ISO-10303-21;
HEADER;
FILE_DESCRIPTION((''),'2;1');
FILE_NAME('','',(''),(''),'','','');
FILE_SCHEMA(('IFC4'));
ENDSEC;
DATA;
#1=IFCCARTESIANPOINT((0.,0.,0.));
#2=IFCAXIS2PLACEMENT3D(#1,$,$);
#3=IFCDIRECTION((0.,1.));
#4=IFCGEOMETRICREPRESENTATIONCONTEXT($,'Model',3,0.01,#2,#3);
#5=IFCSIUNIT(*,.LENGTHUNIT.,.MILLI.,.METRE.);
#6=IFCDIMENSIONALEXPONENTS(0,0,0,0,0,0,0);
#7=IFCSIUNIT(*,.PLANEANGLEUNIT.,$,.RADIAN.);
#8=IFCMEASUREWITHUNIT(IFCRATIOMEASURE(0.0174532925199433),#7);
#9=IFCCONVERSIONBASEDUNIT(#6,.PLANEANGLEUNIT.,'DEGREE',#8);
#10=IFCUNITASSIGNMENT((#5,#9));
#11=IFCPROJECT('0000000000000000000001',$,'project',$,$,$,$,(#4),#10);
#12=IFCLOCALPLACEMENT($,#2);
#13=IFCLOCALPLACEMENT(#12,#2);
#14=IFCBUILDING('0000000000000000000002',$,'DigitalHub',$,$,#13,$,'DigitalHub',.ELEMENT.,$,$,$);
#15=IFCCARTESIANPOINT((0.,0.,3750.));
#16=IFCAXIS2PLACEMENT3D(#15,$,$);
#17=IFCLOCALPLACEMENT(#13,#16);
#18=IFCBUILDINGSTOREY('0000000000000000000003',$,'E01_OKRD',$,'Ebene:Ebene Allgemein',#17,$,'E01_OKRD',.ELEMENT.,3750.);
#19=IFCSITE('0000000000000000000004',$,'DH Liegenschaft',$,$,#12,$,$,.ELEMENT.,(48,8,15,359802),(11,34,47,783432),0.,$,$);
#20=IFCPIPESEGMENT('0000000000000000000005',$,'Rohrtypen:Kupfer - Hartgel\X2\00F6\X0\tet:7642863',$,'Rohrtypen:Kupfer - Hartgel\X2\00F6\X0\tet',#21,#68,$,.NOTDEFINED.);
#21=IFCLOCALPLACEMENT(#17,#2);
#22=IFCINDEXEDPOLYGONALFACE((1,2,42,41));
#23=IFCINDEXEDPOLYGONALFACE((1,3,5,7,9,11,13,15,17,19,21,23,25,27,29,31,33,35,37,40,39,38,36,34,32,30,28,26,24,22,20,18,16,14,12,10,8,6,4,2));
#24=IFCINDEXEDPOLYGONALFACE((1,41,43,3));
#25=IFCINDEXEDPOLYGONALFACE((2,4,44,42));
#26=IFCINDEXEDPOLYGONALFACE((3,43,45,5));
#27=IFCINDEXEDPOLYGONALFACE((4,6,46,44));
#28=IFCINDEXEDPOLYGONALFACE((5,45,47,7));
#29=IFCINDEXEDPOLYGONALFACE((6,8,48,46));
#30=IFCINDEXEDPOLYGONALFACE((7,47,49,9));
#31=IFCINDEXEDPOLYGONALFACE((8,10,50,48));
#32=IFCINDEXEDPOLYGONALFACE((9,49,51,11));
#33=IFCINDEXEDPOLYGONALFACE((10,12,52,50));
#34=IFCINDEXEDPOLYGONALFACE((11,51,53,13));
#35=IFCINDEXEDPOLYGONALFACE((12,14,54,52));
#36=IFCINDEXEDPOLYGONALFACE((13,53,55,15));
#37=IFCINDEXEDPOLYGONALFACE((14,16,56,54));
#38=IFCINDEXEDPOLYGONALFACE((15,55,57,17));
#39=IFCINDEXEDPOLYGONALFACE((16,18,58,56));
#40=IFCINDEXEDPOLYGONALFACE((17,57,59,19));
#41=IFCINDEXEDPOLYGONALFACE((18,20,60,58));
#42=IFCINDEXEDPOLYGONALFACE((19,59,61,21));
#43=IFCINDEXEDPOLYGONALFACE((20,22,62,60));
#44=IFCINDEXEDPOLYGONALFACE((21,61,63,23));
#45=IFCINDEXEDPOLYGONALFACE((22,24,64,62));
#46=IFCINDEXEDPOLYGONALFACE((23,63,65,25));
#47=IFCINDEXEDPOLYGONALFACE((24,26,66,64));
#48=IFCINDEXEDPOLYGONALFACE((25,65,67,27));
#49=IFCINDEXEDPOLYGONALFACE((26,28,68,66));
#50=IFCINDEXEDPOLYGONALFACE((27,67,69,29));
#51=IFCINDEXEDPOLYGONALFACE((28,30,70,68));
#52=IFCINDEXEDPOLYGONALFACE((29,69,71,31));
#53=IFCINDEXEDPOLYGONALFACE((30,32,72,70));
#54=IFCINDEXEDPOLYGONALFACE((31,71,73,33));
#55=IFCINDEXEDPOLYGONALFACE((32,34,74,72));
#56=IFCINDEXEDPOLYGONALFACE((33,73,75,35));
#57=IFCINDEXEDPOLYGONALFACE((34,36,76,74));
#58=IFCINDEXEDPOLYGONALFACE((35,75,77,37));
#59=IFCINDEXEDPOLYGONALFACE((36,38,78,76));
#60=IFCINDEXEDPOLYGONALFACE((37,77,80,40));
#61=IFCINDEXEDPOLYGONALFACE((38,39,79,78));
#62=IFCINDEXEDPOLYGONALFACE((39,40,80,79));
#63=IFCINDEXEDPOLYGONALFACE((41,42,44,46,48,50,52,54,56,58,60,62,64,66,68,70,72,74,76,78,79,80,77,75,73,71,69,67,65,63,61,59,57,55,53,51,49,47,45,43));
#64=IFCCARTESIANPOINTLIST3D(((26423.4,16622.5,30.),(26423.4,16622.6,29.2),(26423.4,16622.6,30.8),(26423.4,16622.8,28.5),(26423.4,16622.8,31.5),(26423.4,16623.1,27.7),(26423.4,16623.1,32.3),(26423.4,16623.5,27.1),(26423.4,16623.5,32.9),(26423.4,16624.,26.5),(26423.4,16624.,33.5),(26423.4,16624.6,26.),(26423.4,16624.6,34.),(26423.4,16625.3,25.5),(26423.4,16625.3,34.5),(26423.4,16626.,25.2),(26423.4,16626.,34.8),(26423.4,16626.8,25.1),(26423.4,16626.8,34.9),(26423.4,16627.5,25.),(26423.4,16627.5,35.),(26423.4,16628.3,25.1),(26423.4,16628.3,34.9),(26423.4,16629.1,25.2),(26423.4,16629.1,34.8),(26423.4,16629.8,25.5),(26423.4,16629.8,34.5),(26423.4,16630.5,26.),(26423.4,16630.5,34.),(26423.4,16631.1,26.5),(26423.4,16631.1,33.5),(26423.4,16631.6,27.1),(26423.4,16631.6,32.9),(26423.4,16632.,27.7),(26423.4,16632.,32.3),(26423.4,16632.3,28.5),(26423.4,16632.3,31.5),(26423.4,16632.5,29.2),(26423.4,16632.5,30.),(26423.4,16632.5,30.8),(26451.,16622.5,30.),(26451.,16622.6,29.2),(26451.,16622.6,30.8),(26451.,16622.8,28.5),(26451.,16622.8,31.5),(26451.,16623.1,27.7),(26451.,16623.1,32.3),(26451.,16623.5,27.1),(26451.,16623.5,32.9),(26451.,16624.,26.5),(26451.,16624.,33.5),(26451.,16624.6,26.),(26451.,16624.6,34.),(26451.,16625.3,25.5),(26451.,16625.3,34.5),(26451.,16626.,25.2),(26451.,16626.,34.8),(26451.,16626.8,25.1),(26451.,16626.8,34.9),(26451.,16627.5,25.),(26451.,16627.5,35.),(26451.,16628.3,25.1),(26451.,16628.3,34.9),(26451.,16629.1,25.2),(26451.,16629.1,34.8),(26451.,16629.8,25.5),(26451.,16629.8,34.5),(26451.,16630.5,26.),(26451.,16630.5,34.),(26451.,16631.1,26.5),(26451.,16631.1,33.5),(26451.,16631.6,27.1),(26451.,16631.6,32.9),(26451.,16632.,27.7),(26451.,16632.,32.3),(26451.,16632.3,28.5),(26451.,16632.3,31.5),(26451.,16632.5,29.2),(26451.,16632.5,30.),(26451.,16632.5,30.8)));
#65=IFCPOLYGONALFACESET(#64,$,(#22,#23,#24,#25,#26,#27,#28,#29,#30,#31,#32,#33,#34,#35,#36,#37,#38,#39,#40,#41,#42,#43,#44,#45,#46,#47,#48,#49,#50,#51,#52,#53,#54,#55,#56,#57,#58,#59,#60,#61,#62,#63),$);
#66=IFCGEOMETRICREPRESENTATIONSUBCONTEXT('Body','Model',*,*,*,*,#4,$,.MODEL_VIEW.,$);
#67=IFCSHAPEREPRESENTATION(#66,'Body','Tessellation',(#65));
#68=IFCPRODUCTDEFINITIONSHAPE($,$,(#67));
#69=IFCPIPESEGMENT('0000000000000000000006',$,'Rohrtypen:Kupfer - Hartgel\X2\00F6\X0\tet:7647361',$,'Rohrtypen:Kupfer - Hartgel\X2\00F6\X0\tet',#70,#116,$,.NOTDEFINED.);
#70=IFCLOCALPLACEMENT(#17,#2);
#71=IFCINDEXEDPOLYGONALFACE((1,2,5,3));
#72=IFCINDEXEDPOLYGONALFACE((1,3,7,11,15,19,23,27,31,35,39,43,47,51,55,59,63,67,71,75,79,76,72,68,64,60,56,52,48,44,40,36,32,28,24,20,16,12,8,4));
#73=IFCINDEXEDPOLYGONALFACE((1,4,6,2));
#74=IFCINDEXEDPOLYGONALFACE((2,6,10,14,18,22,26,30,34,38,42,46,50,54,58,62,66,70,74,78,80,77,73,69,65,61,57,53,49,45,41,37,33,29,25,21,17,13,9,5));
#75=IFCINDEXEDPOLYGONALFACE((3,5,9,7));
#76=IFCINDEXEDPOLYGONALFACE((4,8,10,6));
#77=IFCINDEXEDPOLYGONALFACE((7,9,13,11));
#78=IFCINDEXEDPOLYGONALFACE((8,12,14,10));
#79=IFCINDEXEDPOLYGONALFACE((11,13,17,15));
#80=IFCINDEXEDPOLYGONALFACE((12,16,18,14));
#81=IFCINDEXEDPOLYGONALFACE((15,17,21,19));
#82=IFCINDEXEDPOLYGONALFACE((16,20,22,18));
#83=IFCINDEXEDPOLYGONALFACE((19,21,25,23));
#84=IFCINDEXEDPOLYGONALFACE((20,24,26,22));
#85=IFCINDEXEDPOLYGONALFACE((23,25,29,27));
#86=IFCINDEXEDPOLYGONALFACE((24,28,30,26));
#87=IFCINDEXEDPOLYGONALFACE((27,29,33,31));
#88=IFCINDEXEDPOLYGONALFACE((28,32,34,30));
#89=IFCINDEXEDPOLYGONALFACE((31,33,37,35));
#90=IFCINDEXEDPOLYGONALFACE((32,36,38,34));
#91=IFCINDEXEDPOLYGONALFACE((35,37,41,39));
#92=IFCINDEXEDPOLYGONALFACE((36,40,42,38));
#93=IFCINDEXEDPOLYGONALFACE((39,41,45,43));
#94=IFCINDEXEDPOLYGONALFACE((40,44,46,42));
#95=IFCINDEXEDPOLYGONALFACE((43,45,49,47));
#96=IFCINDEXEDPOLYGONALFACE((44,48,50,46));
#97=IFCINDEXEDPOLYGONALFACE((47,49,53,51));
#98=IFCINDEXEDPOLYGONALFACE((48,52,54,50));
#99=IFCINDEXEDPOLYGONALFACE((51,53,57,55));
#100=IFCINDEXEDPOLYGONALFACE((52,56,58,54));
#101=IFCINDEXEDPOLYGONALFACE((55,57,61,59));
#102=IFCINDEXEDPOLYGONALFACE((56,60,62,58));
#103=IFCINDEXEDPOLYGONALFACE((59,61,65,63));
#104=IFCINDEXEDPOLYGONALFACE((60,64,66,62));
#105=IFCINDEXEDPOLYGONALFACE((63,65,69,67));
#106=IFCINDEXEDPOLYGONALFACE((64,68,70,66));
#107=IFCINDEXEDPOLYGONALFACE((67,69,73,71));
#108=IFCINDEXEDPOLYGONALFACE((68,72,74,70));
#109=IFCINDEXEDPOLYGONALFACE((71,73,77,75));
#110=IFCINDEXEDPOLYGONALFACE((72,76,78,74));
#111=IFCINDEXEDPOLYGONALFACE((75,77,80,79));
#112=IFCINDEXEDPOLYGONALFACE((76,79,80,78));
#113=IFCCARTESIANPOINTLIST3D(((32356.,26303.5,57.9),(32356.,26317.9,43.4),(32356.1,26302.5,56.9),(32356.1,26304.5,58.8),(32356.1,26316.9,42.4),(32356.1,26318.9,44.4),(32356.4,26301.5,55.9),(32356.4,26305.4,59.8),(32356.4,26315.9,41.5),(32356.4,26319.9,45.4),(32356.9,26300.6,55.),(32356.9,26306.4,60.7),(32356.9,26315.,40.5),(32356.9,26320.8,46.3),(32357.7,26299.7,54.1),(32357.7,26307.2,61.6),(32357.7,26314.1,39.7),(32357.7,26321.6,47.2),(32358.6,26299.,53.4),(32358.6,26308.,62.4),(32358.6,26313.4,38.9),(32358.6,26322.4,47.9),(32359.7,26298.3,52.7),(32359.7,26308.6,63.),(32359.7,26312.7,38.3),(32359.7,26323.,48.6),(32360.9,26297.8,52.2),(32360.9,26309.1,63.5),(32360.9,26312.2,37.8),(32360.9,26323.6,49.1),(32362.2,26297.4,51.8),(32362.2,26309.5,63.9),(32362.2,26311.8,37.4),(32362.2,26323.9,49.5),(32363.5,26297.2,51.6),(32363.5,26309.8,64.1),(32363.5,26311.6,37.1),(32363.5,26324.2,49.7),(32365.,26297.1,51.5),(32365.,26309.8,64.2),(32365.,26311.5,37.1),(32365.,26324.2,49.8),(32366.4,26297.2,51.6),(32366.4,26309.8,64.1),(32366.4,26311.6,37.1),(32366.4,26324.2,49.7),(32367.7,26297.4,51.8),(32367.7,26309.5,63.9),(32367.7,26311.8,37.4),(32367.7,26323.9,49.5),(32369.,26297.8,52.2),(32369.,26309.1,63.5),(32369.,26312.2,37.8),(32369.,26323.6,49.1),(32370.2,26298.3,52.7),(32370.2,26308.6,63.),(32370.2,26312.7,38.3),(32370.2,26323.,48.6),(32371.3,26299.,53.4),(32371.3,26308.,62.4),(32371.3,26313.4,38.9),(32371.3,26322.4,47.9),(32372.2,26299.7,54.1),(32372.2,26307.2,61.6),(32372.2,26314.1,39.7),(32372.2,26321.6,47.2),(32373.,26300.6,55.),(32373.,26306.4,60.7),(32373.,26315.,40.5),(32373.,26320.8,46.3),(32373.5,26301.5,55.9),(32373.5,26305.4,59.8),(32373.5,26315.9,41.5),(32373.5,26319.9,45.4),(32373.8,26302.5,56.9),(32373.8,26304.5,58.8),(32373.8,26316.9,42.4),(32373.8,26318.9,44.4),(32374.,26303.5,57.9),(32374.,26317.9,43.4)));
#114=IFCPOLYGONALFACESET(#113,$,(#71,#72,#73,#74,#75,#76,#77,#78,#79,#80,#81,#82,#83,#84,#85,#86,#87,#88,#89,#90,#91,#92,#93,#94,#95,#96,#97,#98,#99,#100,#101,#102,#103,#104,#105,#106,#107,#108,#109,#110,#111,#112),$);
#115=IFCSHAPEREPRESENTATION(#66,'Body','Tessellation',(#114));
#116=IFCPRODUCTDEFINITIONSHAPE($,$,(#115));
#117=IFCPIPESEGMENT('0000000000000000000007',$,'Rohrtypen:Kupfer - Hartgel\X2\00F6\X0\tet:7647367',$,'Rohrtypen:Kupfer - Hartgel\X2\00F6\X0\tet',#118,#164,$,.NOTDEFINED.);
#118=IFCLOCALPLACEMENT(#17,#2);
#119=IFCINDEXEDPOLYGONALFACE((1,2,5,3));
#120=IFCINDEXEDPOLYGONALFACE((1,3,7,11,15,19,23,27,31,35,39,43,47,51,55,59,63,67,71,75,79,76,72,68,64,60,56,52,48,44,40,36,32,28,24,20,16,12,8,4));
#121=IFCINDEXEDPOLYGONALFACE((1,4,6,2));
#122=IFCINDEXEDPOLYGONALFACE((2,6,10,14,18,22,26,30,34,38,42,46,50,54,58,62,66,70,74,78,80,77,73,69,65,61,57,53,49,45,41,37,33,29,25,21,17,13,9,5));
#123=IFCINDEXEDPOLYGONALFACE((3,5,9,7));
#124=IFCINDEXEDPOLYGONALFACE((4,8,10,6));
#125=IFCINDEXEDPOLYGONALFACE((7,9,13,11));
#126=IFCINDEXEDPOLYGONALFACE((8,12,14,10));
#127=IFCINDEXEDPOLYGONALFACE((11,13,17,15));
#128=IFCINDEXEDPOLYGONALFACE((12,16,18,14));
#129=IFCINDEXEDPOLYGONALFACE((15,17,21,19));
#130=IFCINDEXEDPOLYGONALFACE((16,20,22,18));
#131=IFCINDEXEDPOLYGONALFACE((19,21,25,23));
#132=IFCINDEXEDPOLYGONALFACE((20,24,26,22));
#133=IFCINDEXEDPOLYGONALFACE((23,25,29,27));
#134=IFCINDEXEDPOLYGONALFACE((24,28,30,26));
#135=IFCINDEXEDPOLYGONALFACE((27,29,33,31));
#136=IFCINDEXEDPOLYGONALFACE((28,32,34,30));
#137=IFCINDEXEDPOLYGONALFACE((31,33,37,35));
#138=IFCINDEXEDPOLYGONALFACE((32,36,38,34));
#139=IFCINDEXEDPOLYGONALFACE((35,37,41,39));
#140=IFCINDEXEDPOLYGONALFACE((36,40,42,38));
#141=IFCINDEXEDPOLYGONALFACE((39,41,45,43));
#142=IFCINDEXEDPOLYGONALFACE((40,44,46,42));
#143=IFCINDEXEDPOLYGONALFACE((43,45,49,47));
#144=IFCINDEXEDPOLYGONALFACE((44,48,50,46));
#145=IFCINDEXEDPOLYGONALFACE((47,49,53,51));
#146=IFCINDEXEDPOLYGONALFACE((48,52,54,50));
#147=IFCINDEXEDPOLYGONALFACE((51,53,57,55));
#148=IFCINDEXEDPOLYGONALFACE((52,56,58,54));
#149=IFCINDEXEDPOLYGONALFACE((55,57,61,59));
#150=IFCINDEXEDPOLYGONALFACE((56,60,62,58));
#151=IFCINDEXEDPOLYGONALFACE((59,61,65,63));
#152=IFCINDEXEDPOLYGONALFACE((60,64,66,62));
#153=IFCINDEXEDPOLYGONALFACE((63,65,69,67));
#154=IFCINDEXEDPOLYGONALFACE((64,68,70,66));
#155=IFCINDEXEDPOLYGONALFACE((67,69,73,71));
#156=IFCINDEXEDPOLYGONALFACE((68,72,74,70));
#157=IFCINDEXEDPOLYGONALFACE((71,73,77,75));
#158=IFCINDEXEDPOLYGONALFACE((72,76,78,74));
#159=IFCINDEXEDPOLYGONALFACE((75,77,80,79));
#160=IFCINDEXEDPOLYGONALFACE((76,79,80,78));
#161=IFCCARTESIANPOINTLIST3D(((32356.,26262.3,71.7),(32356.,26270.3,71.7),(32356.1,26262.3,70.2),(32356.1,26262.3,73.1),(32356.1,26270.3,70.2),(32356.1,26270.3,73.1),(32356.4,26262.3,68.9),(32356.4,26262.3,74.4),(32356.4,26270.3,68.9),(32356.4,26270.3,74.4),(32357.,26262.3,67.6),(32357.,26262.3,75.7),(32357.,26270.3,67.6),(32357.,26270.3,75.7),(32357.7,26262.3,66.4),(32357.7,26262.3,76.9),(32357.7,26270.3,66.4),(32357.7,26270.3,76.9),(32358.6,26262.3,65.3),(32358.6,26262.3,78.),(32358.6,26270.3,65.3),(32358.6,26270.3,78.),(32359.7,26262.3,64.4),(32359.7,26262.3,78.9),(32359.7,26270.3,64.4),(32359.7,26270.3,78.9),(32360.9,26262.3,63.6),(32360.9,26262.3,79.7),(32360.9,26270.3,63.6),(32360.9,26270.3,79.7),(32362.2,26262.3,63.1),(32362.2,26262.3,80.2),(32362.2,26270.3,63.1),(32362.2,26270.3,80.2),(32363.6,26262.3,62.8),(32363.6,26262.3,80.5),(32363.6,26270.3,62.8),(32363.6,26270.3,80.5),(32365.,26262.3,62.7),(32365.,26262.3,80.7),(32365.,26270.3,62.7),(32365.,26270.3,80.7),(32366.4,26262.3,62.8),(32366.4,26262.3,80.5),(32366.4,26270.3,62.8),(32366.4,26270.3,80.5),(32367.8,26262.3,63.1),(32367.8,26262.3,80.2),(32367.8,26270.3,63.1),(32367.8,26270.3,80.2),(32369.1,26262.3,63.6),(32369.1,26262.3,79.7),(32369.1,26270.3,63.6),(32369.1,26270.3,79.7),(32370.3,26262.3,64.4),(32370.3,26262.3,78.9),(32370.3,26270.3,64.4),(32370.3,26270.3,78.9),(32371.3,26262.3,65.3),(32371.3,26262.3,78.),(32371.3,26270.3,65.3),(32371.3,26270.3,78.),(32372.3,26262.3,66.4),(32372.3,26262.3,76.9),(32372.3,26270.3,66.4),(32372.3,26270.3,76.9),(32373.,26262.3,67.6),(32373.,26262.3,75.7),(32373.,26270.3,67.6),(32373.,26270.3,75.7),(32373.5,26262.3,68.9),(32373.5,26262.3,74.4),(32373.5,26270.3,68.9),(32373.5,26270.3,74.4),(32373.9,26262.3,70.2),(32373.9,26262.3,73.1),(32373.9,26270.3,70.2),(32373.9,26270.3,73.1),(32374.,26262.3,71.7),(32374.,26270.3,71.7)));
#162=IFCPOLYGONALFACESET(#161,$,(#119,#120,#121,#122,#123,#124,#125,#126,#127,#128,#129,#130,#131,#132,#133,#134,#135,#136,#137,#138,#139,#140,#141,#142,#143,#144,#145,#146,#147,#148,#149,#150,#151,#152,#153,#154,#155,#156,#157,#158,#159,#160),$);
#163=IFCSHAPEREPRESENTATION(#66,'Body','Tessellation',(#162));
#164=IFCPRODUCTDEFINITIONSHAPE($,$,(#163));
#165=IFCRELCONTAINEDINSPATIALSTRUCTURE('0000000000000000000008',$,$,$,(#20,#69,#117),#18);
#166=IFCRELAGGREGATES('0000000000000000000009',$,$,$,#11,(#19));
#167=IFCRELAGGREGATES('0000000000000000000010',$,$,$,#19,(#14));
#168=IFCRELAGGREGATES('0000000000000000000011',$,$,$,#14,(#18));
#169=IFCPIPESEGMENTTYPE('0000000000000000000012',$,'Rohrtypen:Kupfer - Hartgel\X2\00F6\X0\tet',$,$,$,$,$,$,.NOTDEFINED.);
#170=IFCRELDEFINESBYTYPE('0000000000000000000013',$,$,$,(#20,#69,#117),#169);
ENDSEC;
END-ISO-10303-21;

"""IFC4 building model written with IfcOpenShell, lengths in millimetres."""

from ifc_helpers import new_model, entity, si_unit, converted_unit, direction, frame, origin, place, context, subcontext, project, spatial, indexed_curve, outline, extrude, type_object, element, save


model = new_model("IFC4")

# Units and contexts
model_context = context("Model", 3, precision=0.01, world=origin(), true_north=direction((0.0, 1.0)))
body_context = subcontext(model_context, "Body", "Model", "MODEL_VIEW")
ifc_project = project(units=[si_unit("LENGTHUNIT", "METRE", prefix="MILLI"), converted_unit("PLANEANGLEUNIT", "DEGREE", entity("IfcRatioMeasure", 0.0174532925199433), si_unit("PLANEANGLEUNIT", "RADIAN"), dimensions=[0, 0, 0, 0, 0, 0, 0])], contexts=[model_context])

# Site, building, storey
site_placement = place(None, origin())
site = spatial("IfcSite", under=ifc_project, at=site_placement, Name="DH Liegenschaft", CompositionType="ELEMENT", RefLatitude=(48, 8, 15, 359802), RefLongitude=(11, 34, 47, 783432), RefElevation=0.0)
building_placement = place(site_placement, origin())
building = spatial("IfcBuilding", under=site, at=building_placement, Name="DigitalHub", LongName="DigitalHub", CompositionType="ELEMENT")
storey_placement = place(building_placement, frame((0.0, 0.0, 3750.0)))
storey = spatial("IfcBuildingStorey", under=building, at=storey_placement, Name="E01_OKRD", ObjectType="Ebene:Ebene Allgemein", LongName="E01_OKRD", CompositionType="ELEMENT", Elevation=3750.0)

# Pipe segments
pipe_segment_type = type_object("IfcPipeSegmentType", Name="Rohrtypen:Kupfer - Hartgelötet", PredefinedType="NOTDEFINED")
pipe_segment_1_placement = place(storey_placement, frame((26423.4, 16620.9, 23.4)))
element("IfcPipeSegment", 1, at=pipe_segment_1_placement, inside=storey, type_object=pipe_segment_type, Name="Rohrtypen:Kupfer - Hartgelötet:7642863", ObjectType="Rohrtypen:Kupfer - Hartgelötet", PredefinedType="NOTDEFINED", context=body_context, shape_type="SweptSolid", body=[
    extrude(outline(indexed_curve([(5.0, 0.0), (4.9, 0.8), (4.8, 1.5), (4.5, 2.3), (4.0, 2.9), (3.5, 3.5), (2.9, 4.0), (2.3, 4.5), (1.5, 4.8), (0.8, 4.9), (0.0, 5.0), (-0.8, 4.9), (-1.5, 4.8), (-2.3, 4.5), (-2.9, 4.0), (-3.5, 3.5), (-4.0, 2.9), (-4.5, 2.3), (-4.8, 1.5), (-4.9, 0.8), (-5.0, 0.0), (-4.9, -0.8), (-4.8, -1.5), (-4.5, -2.3), (-4.0, -2.9), (-3.5, -3.5), (-2.9, -4.0), (-2.3, -4.5), (-1.5, -4.8), (-0.8, -4.9), (0.0, -5.0), (0.8, -4.9), (1.5, -4.8), (2.3, -4.5), (2.9, -4.0), (3.5, -3.5), (4.0, -2.9), (4.5, -2.3), (4.8, -1.5), (4.9, -0.8), (5.0, 0.0)], self_intersect=False)), frame((0.0, 6.6, 6.6), z_axis=(1.0, 0.0, 0.0), x_axis=(0.0, 1.0, 0.0)), (0.0, 0.0, 1.0), 27.6),
])
pipe_segment_2_placement = place(storey_placement, frame((32354.4, 26295.5, 35.5)))
element("IfcPipeSegment", 2, at=pipe_segment_2_placement, inside=storey, type_object=pipe_segment_type, Name="Rohrtypen:Kupfer - Hartgelötet:7647361", ObjectType="Rohrtypen:Kupfer - Hartgelötet", PredefinedType="NOTDEFINED", context=body_context, shape_type="SweptSolid", body=[
    extrude(outline(indexed_curve([(9.0, 0.0), (8.9, 1.4), (8.6, 2.8), (8.0, 4.1), (7.3, 5.3), (6.4, 6.4), (5.3, 7.3), (4.1, 8.0), (2.8, 8.6), (1.4, 8.9), (0.0, 9.0), (-1.4, 8.9), (-2.8, 8.6), (-4.1, 8.0), (-5.3, 7.3), (-6.4, 6.4), (-7.3, 5.3), (-8.0, 4.1), (-8.6, 2.8), (-8.9, 1.4), (-9.0, 0.0), (-8.9, -1.4), (-8.6, -2.8), (-8.0, -4.1), (-7.3, -5.3), (-6.4, -6.4), (-5.3, -7.3), (-4.1, -8.0), (-2.8, -8.6), (-1.4, -8.9), (0.0, -9.0), (1.4, -8.9), (2.8, -8.6), (4.1, -8.0), (5.3, -7.3), (6.4, -6.4), (7.3, -5.3), (8.0, -4.1), (8.6, -2.8), (8.9, -1.4), (9.0, 0.0)], self_intersect=False)), frame((10.6, 22.4, 8.0), z_axis=(0.0, -0.707107, 0.707107), x_axis=(-1.0, 0.0, 0.0)), (0.0, 0.0, 1.0), 20.4),
])
pipe_segment_3_placement = place(storey_placement, frame((32354.4, 26262.3, 61.1)))
element("IfcPipeSegment", 3, at=pipe_segment_3_placement, inside=storey, type_object=pipe_segment_type, Name="Rohrtypen:Kupfer - Hartgelötet:7647367", ObjectType="Rohrtypen:Kupfer - Hartgelötet", PredefinedType="NOTDEFINED", context=body_context, shape_type="SweptSolid", body=[
    extrude(outline(indexed_curve([(9.0, 0.0), (8.9, 1.4), (8.6, 2.8), (8.0, 4.1), (7.3, 5.3), (6.4, 6.4), (5.3, 7.3), (4.1, 8.0), (2.8, 8.6), (1.4, 8.9), (0.0, 9.0), (-1.4, 8.9), (-2.8, 8.6), (-4.1, 8.0), (-5.3, 7.3), (-6.4, 6.4), (-7.3, 5.3), (-8.0, 4.1), (-8.6, 2.8), (-8.9, 1.4), (-9.0, 0.0), (-8.9, -1.4), (-8.6, -2.8), (-8.0, -4.1), (-7.3, -5.3), (-6.4, -6.4), (-5.3, -7.3), (-4.1, -8.0), (-2.8, -8.6), (-1.4, -8.9), (0.0, -9.0), (1.4, -8.9), (2.8, -8.6), (4.1, -8.0), (5.3, -7.3), (6.4, -6.4), (7.3, -5.3), (8.0, -4.1), (8.6, -2.8), (8.9, -1.4), (9.0, 0.0)], self_intersect=False)), frame((10.6, 8.0, 10.6), z_axis=(0.000049, -1.0, 0.0), x_axis=(-1.0, -0.000049, 0.0)), (0.0, 0.0, 1.0), 8.0),
])

save(model, "model.ifc")
